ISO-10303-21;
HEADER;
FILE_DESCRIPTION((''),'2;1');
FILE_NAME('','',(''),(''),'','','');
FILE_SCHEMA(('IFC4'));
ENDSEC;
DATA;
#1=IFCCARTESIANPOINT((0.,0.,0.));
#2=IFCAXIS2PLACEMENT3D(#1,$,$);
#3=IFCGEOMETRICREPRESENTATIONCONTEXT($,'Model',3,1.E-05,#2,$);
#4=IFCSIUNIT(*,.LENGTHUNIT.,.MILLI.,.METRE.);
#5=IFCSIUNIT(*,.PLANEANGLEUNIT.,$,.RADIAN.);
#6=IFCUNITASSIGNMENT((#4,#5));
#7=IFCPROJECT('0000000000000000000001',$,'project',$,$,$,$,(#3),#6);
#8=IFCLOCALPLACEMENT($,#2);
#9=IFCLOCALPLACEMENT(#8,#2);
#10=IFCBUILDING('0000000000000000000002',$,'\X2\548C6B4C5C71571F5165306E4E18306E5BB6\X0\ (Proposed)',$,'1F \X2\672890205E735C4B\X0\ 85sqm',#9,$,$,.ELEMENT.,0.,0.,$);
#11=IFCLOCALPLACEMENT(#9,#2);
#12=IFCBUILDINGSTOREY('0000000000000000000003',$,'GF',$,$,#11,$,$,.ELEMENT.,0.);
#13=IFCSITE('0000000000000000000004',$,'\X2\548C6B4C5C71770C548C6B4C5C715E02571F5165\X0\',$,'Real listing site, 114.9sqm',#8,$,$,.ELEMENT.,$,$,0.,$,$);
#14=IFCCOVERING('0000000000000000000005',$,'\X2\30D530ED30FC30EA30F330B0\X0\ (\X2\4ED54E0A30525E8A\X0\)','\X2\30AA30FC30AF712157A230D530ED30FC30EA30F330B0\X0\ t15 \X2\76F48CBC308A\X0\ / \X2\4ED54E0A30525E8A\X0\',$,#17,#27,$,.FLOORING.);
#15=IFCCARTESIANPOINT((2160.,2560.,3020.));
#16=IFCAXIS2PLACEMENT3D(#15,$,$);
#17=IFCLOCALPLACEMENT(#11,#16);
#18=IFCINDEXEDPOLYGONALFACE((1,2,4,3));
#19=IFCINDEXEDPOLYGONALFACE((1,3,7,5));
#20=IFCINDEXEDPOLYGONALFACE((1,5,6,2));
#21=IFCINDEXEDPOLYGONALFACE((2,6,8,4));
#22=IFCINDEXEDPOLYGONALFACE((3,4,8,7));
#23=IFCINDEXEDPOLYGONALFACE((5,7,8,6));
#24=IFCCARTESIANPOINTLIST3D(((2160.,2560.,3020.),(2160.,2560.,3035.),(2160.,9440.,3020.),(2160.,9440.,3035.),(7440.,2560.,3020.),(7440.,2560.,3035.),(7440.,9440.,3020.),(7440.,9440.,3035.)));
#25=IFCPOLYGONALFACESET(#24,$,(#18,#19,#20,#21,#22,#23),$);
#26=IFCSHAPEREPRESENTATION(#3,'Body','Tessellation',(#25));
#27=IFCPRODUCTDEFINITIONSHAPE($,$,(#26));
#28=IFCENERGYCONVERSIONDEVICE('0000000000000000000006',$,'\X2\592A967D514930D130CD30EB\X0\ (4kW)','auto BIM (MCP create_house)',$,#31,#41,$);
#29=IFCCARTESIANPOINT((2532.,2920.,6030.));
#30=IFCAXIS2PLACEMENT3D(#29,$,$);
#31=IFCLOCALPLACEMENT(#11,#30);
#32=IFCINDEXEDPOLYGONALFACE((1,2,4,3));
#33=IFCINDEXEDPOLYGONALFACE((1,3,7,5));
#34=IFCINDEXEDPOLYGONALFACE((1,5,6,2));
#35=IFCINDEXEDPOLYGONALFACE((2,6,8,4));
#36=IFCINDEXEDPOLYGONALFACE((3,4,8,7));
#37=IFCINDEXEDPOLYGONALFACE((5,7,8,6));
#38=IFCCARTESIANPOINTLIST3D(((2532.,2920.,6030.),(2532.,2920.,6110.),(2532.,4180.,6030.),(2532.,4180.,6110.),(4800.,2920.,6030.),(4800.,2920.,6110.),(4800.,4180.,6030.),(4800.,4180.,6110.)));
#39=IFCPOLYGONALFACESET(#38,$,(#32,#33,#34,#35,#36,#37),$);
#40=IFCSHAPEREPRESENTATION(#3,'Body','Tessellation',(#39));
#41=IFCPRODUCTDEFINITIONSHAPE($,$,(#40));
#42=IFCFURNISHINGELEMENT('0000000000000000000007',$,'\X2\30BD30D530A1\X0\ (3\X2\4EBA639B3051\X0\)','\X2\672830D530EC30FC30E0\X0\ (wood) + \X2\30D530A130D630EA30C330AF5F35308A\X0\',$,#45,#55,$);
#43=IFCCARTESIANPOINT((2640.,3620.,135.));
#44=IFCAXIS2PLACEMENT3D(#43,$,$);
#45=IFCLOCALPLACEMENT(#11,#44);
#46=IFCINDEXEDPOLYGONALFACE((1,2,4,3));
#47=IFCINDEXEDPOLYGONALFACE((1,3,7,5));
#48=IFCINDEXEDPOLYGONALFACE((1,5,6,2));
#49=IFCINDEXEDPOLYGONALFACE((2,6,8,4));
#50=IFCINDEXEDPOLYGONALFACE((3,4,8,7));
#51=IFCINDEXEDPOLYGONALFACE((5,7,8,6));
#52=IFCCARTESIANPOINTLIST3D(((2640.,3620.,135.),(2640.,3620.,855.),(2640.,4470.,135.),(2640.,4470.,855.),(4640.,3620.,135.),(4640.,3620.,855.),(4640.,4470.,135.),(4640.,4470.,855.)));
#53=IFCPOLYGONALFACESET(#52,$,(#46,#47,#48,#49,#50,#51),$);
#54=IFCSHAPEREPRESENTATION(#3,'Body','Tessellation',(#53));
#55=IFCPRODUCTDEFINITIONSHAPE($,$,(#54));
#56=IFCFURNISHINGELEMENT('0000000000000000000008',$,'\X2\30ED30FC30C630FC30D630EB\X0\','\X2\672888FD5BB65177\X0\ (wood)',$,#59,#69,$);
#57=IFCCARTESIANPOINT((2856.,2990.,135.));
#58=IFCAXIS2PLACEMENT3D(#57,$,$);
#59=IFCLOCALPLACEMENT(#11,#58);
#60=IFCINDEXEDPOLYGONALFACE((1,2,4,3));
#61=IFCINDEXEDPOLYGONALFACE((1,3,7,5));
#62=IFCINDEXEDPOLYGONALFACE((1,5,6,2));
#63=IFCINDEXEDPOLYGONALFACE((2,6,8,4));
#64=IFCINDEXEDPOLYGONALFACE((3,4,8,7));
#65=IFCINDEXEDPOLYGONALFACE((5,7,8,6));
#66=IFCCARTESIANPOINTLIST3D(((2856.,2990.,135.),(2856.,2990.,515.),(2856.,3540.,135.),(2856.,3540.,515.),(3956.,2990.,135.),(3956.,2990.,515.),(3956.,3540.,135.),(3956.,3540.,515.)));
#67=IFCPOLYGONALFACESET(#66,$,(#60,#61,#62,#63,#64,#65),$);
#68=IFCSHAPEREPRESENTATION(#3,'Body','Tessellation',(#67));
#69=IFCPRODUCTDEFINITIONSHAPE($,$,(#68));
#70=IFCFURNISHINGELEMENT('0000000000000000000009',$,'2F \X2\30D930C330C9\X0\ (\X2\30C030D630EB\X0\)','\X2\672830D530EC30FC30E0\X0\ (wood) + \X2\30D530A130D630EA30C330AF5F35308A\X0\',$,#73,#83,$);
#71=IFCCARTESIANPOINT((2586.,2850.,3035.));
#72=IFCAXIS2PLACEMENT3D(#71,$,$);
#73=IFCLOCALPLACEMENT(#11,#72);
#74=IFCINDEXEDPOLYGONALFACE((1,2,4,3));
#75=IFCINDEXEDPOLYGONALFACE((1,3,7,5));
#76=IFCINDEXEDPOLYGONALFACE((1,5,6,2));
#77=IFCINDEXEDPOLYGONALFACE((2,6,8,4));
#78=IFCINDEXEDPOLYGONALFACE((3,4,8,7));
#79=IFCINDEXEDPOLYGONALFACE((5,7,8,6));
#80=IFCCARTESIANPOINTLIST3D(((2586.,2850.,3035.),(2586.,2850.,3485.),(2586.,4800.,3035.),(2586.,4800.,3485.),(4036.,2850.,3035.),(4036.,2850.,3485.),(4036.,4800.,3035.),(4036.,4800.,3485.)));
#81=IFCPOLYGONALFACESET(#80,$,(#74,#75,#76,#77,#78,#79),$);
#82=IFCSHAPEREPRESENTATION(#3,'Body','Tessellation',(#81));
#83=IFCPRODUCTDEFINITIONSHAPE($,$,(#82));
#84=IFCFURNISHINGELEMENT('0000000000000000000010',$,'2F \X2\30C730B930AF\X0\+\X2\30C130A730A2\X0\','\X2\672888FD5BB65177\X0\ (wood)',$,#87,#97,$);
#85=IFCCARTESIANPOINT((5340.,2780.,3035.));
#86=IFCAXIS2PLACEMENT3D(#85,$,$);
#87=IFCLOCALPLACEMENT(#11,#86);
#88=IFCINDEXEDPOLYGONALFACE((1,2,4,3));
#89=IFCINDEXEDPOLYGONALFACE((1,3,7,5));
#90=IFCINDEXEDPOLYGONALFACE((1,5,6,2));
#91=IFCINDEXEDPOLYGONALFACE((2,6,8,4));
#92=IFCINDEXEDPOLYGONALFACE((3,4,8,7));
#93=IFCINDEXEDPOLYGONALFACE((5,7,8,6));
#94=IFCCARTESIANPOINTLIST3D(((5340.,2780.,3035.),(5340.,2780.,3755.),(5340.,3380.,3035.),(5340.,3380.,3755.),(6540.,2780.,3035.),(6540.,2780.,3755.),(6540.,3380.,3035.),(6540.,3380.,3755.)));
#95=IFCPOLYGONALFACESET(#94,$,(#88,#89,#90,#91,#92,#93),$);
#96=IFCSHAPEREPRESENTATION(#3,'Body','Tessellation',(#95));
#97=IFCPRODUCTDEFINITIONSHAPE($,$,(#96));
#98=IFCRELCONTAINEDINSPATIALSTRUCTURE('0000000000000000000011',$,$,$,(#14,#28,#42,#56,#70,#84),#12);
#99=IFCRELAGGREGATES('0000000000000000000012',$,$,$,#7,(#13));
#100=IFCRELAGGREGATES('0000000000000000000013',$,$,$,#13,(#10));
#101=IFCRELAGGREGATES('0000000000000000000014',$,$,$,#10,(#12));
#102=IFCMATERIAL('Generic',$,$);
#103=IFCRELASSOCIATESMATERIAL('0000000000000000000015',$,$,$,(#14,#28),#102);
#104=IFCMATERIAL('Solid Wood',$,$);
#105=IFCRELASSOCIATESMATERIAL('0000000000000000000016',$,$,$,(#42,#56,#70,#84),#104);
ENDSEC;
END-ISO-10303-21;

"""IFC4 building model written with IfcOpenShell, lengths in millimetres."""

from ifc_helpers import new_model, si_unit, frame, frame_2d, origin, place, context, project, spatial, rectangle, extrude, material, element, save


model = new_model("IFC4")

# Units and contexts
model_context = context("Model", 3, precision=1e-05, world=origin())
ifc_project = project(units=[si_unit("LENGTHUNIT", "METRE", prefix="MILLI"), si_unit("PLANEANGLEUNIT", "RADIAN")], contexts=[model_context])

# Site, building, storey
site_placement = place(None, origin())
site = spatial("IfcSite", under=ifc_project, at=site_placement, Name="和歌山県和歌山市土入", ObjectType="Real listing site, 114.9sqm", CompositionType="ELEMENT", RefElevation=0.0)
building_placement = place(site_placement, origin())
building = spatial("IfcBuilding", under=site, at=building_placement, Name="和歌山土入の丘の家 (Proposed)", ObjectType="1F 木造平屋 85sqm", CompositionType="ELEMENT", ElevationOfRefHeight=0.0, ElevationOfTerrain=0.0)
storey_placement = place(building_placement, origin())
storey = spatial("IfcBuildingStorey", under=building, at=storey_placement, Name="GF", CompositionType="ELEMENT", Elevation=0.0)

# Shared definitions
ifc_material_1 = material(Name="Solid Wood")

# Shared definitions
ifc_material_2 = material(Name="Generic")

# Covering
covering_placement = place(storey_placement, frame((2160.0, 2560.0, 3020.0)))
element("IfcCovering", 1, at=covering_placement, inside=storey, material=ifc_material_2, Name="フローリング (仕上げ床)", Description="オーク無垢フローリング t15 直貼り / 仕上げ床", PredefinedType="FLOORING", context=model_context, shape_type="SweptSolid", body=[
    extrude(rectangle(XDim=5280.0, YDim=6880.0, at=frame_2d((2640.0, 3440.0))), frame((2160.0, 2560.0, 3020.0)), (0.0, 0.0, 1.0), 15.0),
])

# Energy conversion device
energy_conversion_device_placement = place(storey_placement, frame((2532.0, 2920.0, 6030.0)))
element("IfcEnergyConversionDevice", 2, at=energy_conversion_device_placement, inside=storey, material=ifc_material_2, Name="太陽光パネル (4kW)", Description="auto BIM (MCP create_house)", context=model_context, shape_type="SweptSolid", body=[
    extrude(rectangle(XDim=2268.0, YDim=1260.0, at=frame_2d((1134.0, 630.0))), frame((2532.0, 2920.0, 6030.0)), (0.0, 0.0, 1.0), 80.0),
])

# Furnishing elements
furnishing_1_placement = place(storey_placement, frame((2640.0, 3620.0, 135.0)))
element("IfcFurnishingElement", 3, at=furnishing_1_placement, inside=storey, material=ifc_material_1, Name="ソファ (3人掛け)", Description="木フレーム (wood) + ファブリック張り", context=model_context, shape_type="SweptSolid", body=[
    extrude(rectangle(XDim=2000.0, YDim=850.0, at=frame_2d((1000.0, 425.0))), frame((2640.0, 3620.0, 135.0)), (0.0, 0.0, 1.0), 720.0),
])
furnishing_2_placement = place(storey_placement, frame((2856.0, 2990.0, 135.0)))
element("IfcFurnishingElement", 4, at=furnishing_2_placement, inside=storey, material=ifc_material_1, Name="ローテーブル", Description="木製家具 (wood)", context=model_context, shape_type="SweptSolid", body=[
    extrude(rectangle(XDim=1100.0, YDim=550.0, at=frame_2d((550.0, 275.0))), frame((2856.0, 2990.0, 135.0)), (0.0, 0.0, 1.0), 380.0),
])
furnishing_3_placement = place(storey_placement, frame((2586.0, 2850.0, 3035.0)))
element("IfcFurnishingElement", 5, at=furnishing_3_placement, inside=storey, material=ifc_material_1, Name="2F ベッド (ダブル)", Description="木フレーム (wood) + ファブリック張り", context=model_context, shape_type="SweptSolid", body=[
    extrude(rectangle(XDim=1450.0, YDim=1950.0, at=frame_2d((725.0, 975.0))), frame((2586.0, 2850.0, 3035.0)), (0.0, 0.0, 1.0), 450.0),
])
furnishing_4_placement = place(storey_placement, frame((5340.0, 2780.0, 3035.0)))
element("IfcFurnishingElement", 6, at=furnishing_4_placement, inside=storey, material=ifc_material_1, Name="2F デスク+チェア", Description="木製家具 (wood)", context=model_context, shape_type="SweptSolid", body=[
    extrude(rectangle(XDim=1200.0, YDim=600.0, at=frame_2d((600.0, 300.0))), frame((5340.0, 2780.0, 3035.0)), (0.0, 0.0, 1.0), 720.0),
])

save(model, "model.ifc")
